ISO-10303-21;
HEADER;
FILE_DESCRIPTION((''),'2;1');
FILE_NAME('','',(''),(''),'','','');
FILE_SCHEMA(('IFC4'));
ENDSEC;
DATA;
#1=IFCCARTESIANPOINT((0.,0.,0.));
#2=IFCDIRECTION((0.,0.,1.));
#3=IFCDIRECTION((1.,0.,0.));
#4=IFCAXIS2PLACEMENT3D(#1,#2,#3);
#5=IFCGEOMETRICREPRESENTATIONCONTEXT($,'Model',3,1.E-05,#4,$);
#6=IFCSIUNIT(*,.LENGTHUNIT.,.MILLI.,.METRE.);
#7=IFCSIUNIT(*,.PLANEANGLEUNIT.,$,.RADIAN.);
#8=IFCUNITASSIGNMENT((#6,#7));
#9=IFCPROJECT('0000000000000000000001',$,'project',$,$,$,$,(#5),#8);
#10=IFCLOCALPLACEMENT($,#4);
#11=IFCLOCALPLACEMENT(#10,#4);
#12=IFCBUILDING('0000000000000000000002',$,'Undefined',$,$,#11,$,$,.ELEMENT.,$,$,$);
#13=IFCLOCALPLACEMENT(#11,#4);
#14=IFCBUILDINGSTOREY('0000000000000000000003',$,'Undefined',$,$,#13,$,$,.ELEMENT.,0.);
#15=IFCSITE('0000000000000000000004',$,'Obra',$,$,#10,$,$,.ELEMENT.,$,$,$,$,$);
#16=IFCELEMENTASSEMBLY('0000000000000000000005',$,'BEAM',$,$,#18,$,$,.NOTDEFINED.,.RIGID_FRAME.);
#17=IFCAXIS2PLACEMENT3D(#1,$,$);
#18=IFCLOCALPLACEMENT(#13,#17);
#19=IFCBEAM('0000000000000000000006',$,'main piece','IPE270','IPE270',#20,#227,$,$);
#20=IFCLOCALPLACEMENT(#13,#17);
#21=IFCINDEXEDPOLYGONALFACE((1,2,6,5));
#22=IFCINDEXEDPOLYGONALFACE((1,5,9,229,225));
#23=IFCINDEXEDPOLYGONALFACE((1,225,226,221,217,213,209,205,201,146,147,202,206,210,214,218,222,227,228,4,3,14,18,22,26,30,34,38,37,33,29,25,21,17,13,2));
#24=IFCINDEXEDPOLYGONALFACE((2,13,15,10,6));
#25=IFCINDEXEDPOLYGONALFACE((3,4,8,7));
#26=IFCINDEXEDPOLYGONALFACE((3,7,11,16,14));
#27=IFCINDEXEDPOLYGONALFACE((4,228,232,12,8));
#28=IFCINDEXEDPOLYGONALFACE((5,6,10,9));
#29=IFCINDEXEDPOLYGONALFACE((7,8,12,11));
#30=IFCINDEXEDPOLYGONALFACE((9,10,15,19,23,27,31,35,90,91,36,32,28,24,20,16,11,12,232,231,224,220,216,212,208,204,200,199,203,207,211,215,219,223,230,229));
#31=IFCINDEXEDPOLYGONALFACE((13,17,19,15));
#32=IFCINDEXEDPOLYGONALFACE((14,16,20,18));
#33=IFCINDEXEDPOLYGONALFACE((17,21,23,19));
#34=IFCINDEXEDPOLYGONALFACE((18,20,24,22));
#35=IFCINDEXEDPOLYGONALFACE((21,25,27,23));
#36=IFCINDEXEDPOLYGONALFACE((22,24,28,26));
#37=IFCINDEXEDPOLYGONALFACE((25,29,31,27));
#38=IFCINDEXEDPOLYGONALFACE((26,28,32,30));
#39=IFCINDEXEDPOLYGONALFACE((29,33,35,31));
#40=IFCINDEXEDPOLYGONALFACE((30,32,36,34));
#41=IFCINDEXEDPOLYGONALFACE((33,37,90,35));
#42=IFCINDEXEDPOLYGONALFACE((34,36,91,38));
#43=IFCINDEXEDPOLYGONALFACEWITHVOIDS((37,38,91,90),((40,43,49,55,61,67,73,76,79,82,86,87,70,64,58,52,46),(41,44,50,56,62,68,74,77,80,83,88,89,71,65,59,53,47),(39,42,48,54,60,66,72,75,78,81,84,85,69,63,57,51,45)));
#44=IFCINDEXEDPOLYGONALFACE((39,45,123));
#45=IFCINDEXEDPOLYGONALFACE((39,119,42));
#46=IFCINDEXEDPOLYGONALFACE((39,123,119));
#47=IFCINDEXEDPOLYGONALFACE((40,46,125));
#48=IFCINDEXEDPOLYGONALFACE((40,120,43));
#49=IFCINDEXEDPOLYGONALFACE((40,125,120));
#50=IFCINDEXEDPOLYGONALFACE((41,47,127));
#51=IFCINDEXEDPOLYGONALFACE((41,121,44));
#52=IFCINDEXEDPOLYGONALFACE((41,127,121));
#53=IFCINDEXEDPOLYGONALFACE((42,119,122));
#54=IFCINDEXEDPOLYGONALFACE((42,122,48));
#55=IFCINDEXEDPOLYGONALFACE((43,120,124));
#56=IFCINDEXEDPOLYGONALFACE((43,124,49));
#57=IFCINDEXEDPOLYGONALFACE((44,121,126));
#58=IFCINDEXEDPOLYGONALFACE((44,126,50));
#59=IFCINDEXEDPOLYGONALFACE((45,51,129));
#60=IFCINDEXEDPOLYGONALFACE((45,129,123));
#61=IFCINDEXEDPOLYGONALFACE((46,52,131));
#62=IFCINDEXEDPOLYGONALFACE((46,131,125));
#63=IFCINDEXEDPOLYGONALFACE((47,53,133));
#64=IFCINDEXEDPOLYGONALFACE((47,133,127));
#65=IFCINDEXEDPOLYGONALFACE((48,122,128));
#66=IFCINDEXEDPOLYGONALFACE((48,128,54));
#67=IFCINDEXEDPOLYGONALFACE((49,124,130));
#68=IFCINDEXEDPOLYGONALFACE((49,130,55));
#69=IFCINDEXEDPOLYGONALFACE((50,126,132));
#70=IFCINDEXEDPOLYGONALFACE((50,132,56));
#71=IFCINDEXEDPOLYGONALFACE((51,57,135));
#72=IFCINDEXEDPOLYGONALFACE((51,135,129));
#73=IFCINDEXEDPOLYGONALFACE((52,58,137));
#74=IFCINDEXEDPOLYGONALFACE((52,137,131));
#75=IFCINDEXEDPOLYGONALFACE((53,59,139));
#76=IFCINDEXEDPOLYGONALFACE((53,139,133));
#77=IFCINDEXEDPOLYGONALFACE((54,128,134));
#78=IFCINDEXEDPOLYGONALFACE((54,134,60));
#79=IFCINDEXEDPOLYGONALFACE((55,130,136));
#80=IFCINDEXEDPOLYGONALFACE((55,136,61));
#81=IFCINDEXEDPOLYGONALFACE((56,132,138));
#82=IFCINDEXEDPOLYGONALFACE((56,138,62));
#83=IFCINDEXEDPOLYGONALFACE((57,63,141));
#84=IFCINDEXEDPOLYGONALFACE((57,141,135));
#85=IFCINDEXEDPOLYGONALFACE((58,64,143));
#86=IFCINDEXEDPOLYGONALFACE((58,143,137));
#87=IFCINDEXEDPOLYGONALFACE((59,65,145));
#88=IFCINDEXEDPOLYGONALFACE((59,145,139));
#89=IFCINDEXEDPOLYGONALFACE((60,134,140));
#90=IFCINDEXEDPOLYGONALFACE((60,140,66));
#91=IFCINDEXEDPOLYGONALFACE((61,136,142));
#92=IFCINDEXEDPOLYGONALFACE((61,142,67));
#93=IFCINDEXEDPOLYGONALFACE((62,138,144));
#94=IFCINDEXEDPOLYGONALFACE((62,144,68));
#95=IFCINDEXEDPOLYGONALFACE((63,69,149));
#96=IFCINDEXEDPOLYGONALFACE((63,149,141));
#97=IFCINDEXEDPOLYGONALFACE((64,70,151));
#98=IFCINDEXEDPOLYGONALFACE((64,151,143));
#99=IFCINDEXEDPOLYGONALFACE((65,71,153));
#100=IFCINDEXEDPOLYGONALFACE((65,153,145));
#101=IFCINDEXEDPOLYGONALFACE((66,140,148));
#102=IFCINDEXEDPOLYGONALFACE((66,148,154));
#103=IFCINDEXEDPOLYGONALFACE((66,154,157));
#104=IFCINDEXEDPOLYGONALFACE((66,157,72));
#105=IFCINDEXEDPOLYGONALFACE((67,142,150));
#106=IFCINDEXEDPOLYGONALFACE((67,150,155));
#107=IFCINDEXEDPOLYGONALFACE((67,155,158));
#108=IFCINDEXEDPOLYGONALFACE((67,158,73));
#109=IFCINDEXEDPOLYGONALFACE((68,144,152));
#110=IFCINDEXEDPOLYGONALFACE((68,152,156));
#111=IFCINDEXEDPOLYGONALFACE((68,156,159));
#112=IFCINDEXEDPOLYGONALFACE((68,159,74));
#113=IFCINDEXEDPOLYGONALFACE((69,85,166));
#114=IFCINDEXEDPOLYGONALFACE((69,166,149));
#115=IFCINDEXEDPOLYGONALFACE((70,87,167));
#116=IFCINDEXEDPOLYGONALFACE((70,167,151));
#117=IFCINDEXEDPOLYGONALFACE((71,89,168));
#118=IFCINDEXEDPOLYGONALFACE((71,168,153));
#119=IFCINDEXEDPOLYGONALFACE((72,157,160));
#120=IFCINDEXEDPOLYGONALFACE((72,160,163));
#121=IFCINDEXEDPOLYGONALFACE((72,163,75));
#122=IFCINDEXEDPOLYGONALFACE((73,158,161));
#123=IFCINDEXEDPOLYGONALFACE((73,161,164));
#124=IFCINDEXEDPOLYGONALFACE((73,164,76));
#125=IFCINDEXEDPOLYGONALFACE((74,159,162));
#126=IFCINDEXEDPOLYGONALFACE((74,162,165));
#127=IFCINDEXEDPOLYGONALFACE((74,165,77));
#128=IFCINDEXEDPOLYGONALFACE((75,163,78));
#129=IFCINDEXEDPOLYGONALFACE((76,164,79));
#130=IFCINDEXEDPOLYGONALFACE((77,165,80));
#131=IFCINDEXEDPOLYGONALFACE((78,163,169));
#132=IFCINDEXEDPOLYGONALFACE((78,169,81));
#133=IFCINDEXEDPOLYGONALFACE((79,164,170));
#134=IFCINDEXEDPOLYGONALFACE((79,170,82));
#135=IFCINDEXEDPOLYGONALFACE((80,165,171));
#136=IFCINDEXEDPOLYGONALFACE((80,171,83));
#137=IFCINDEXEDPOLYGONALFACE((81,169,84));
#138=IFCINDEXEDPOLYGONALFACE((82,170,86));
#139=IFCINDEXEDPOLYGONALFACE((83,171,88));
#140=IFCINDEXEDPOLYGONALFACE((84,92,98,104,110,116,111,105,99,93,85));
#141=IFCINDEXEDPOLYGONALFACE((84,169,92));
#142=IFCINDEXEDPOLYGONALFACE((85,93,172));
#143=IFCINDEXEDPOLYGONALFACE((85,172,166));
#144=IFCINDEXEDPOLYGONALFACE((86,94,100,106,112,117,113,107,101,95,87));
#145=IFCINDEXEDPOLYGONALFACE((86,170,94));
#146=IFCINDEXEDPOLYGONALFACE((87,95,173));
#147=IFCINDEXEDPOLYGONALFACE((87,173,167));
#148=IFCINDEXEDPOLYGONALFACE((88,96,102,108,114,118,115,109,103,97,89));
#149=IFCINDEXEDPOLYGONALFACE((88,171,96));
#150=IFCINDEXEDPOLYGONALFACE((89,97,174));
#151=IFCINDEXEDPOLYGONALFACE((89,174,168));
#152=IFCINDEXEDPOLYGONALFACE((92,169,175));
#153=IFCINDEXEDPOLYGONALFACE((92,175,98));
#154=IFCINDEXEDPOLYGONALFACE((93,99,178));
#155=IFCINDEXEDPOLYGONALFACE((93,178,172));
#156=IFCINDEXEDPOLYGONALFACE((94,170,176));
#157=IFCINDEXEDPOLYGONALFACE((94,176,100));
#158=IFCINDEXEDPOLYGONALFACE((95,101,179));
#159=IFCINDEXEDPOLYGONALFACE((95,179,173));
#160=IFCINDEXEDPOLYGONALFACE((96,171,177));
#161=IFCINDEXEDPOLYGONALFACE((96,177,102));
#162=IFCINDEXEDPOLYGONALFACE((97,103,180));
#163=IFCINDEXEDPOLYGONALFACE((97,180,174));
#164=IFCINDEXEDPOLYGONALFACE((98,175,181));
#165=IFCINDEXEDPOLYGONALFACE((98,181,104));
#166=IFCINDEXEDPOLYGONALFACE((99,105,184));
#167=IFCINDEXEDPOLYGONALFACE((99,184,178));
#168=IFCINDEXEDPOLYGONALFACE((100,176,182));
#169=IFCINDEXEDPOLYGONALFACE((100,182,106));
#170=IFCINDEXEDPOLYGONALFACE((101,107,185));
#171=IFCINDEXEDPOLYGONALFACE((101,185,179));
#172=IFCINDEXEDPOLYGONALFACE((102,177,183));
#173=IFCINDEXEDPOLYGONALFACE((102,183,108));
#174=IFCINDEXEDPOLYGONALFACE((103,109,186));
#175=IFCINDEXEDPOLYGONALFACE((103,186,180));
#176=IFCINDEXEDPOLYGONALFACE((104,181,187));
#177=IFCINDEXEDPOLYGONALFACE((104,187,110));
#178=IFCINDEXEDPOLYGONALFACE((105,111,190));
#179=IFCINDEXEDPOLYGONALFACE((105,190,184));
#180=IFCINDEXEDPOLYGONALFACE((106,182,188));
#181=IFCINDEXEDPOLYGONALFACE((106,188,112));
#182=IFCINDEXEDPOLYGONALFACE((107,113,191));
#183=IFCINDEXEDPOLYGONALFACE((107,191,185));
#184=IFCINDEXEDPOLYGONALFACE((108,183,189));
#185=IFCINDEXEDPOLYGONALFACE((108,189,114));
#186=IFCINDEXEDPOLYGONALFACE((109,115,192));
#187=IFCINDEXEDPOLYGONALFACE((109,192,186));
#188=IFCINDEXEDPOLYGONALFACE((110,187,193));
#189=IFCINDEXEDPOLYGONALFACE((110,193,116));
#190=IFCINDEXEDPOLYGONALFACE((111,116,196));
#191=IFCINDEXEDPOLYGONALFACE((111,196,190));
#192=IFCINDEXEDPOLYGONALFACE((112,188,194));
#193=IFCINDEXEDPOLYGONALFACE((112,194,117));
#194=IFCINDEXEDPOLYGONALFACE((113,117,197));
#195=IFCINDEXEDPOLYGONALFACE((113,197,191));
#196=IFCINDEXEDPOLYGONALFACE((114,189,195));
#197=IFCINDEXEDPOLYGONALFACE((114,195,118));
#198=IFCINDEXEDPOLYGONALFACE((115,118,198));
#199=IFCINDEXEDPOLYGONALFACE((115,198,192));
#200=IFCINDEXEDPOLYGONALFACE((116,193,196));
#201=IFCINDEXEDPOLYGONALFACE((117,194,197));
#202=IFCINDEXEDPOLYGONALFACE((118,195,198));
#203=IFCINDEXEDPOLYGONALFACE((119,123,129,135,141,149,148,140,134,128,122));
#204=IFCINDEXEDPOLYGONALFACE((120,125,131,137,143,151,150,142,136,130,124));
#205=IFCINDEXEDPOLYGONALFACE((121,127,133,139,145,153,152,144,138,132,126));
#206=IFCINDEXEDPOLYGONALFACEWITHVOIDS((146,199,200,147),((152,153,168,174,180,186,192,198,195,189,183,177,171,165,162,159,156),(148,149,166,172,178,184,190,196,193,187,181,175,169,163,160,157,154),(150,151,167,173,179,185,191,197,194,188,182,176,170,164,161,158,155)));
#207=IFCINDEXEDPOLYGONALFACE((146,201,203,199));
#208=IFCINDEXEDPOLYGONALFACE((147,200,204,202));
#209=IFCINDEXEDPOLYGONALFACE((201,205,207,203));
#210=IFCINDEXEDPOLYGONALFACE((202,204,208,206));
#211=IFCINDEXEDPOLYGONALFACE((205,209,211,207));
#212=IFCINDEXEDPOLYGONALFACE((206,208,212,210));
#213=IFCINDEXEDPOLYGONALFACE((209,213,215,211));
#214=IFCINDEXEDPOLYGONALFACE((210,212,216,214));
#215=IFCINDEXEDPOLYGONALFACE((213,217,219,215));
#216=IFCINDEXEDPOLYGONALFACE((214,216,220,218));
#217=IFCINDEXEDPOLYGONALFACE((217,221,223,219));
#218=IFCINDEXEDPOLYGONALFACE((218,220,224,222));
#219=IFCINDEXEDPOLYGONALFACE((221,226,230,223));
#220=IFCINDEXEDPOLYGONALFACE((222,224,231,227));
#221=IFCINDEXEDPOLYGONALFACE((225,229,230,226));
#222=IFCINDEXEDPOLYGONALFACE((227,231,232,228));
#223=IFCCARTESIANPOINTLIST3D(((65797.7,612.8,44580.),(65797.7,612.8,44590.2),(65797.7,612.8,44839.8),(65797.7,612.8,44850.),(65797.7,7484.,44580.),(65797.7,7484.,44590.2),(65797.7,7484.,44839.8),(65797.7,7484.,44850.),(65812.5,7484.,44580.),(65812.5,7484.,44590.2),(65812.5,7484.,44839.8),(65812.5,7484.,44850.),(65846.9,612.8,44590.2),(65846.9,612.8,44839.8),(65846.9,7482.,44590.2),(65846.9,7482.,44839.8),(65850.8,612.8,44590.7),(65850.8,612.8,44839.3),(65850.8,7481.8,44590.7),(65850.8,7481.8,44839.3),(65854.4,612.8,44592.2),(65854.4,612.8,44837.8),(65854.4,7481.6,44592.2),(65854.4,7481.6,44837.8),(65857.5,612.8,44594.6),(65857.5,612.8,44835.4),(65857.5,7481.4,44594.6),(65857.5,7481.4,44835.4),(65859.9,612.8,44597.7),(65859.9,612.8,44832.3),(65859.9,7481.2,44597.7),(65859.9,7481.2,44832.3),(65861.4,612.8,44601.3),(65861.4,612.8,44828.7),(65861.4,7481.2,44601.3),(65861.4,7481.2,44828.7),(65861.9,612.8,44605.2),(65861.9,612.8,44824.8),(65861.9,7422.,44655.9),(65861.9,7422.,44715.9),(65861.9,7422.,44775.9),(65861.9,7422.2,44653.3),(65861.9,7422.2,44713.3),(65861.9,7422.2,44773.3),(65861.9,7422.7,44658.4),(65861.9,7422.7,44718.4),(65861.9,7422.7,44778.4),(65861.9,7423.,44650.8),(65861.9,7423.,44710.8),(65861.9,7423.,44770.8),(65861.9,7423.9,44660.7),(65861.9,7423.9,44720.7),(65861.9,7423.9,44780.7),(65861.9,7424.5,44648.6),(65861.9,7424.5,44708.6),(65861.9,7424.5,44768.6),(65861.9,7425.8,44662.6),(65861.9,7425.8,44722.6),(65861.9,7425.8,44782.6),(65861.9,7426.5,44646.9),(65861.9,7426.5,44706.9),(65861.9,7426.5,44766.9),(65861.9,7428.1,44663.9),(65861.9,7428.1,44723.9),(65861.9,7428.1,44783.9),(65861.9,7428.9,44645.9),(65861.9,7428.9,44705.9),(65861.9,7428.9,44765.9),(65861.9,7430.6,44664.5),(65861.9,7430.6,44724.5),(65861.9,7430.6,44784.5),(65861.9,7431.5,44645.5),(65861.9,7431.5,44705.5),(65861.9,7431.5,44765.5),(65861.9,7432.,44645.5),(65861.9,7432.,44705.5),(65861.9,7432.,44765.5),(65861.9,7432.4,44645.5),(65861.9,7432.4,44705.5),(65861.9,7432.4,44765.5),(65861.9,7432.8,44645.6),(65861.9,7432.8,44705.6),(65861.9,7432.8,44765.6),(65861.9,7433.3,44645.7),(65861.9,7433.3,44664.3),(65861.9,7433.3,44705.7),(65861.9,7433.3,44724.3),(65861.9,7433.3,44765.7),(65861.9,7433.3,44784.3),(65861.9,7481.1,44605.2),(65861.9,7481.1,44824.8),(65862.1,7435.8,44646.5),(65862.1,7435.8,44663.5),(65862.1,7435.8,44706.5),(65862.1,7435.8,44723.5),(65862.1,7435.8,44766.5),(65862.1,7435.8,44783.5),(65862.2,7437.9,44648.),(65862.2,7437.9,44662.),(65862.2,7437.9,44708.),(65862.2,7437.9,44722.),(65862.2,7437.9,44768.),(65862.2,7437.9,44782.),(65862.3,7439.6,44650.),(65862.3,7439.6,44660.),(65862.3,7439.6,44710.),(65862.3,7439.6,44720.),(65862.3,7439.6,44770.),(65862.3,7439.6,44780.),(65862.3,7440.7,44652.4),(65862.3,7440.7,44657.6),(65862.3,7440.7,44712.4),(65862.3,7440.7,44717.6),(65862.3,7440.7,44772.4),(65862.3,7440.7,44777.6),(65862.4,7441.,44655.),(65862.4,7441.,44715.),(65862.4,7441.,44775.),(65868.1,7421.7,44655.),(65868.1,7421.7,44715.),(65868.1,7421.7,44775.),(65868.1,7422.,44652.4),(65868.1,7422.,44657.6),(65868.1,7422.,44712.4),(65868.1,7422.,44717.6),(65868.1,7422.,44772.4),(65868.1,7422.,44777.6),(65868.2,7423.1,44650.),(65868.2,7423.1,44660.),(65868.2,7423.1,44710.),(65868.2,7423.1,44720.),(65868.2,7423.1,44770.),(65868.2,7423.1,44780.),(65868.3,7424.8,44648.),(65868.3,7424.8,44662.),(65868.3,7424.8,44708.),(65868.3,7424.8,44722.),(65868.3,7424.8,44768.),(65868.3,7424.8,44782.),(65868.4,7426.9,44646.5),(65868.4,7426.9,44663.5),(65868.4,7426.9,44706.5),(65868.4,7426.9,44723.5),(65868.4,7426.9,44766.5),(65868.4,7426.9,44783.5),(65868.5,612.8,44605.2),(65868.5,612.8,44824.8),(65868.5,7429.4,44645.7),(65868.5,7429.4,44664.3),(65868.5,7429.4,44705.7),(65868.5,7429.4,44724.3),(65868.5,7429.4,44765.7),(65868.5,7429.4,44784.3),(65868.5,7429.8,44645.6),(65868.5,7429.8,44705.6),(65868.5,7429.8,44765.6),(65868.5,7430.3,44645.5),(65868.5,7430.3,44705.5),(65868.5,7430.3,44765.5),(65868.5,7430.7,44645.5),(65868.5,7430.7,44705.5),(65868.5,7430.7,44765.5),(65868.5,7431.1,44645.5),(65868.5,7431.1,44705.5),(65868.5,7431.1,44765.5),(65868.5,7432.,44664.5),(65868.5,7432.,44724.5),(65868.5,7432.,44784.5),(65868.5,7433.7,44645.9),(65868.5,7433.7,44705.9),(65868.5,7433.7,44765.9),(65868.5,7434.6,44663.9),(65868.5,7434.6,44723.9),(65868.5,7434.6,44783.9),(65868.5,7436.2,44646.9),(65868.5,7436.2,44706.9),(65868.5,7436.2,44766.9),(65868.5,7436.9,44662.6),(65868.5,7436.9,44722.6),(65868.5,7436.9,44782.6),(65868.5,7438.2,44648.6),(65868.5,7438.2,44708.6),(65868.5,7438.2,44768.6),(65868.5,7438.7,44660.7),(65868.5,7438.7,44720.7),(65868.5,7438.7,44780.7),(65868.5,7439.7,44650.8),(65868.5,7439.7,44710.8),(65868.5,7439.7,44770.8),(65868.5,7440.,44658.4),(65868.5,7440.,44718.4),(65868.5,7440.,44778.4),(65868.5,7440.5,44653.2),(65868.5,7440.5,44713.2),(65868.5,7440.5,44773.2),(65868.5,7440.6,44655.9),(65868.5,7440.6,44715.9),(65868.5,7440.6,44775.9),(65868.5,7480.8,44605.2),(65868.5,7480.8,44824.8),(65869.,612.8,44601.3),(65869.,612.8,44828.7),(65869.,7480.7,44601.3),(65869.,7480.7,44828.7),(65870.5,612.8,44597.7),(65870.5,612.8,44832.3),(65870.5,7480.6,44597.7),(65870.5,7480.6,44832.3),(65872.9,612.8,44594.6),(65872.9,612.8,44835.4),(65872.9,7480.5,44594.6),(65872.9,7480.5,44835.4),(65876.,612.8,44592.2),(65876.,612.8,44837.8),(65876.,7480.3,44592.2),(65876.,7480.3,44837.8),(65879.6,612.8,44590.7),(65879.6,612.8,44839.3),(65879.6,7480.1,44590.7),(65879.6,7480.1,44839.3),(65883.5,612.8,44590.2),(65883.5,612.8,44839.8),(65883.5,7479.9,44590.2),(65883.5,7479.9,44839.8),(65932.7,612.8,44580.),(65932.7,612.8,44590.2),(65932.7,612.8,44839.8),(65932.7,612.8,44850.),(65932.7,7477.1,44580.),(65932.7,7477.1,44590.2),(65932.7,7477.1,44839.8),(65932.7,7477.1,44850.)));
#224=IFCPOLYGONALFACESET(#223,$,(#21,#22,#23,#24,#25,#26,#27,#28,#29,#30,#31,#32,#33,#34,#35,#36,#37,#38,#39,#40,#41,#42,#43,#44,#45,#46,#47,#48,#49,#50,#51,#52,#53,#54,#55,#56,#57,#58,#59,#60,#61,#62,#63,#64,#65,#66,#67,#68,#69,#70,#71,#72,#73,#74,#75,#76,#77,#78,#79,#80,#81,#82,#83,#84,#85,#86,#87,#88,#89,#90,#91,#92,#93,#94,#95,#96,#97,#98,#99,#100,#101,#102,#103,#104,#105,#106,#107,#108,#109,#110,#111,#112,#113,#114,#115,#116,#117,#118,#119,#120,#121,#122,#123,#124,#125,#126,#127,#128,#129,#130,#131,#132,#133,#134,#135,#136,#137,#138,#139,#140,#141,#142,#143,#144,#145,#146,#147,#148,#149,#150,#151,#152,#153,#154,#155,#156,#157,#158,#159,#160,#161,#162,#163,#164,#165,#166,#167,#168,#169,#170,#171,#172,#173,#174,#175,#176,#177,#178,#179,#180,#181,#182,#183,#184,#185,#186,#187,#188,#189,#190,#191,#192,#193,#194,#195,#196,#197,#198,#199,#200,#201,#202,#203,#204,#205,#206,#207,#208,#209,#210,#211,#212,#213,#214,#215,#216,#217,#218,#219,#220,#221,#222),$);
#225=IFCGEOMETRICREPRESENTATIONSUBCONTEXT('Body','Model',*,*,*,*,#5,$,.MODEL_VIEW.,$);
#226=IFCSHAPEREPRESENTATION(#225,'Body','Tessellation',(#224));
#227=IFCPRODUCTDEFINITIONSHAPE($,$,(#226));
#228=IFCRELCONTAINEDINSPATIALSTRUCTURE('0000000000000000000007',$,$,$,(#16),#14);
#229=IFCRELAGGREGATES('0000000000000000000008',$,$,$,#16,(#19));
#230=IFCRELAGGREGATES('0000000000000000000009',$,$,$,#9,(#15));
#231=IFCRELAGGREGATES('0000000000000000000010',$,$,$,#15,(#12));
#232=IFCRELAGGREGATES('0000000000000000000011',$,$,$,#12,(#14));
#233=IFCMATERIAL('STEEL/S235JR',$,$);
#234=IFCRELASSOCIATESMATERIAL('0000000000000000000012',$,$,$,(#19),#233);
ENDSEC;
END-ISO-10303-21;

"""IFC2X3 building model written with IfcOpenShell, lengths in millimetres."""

from ifc_helpers import new_model, si_unit, frame, origin_with_axes, origin_2d_with_axis, place, context, subcontext, project, spatial, circle, i_section, extrude, clip, halfspace, source, transform, mapped, material, element, aggregate, save


model = new_model("IFC2X3")

# Units and contexts
model_context = context("Model", 3, precision=1e-05, world=origin_with_axes())
body_context = subcontext(model_context, "Body", "Model", "MODEL_VIEW")
ifc_project = project(units=[si_unit("LENGTHUNIT", "METRE", prefix="MILLI"), si_unit("PLANEANGLEUNIT", "RADIAN")], contexts=[model_context])

# Site, building, storey
site_placement = place(None, origin_with_axes())
site = spatial("IfcSite", under=ifc_project, at=site_placement, Name="Obra", CompositionType="ELEMENT")
building_placement = place(site_placement, origin_with_axes())
building = spatial("IfcBuilding", under=site, at=building_placement, Name="Undefined", CompositionType="ELEMENT")
storey_placement = place(building_placement, origin_with_axes())
storey = spatial("IfcBuildingStorey", under=building, at=storey_placement, Name="Undefined", CompositionType="ELEMENT", Elevation=0.0)

# Shared definitions
ifc_material_1 = material(Name="STEEL/S235JR")

# Element assembly, beam, opening
assembly_1_placement = place(storey_placement, origin_with_axes())
assembly_1 = element("IfcElementAssembly", 1, at=assembly_1_placement, inside=storey, Name="BEAM", AssemblyPlace="NOTDEFINED", PredefinedType="RIGID_FRAME")
beam_1_placement = place(assembly_1_placement, frame((65865.2, 7484.0, 44715.0), z_axis=(0.0, 0.0, 1.0), x_axis=(0.0, -1.0, 0.0)))
beam_1 = element("IfcBeam", 2, at=beam_1_placement, material=ifc_material_1, Name="main piece", Description="IPE270", ObjectType="IPE270", context=body_context, shape_type="Clipping", body=[
    clip(extrude(i_section(OverallWidth=135.0, OverallDepth=270.0, WebThickness=6.6, FlangeThickness=10.2, FilletRadius=15.0, at=origin_2d_with_axis()), frame((6871.2, 0.0, 0.0), z_axis=(-1.0, 0.0, 0.0), x_axis=(0.0, -1.0, 0.0)), (0.0, 0.0, 1.0), 6871.2), halfspace(frame((4.8, 30.8, -120.0), z_axis=(-0.998369, 0.057091, 0.0), x_axis=(0.0, 0.0, 1.0)), False)),
])
shared_shape_1 = source(origin_with_axes(), body_context, "Body", "SweptSolid", [
    extrude(circle(Radius=9.5, at=origin_2d_with_axis()), frame((0.0, 28.6, 0.0), z_axis=(0.0, 1.0, 0.0), x_axis=(1.0, 0.0, 0.0)), (0.0, 0.0, 1.0), 6.8),
])
opening_1_placement = place(assembly_1_placement, frame((65836.1, 7483.1, 44835.0), z_axis=(-0.05711, -0.998368, 0.0), x_axis=(0.0, 0.0, -1.0)))
element("IfcOpeningElement", 3, at=opening_1_placement, cuts=beam_1, ObjectType="Opening", context=body_context, shape_type="MappedRepresentation", body=[
    mapped(shared_shape_1, transform((60.0, 0.0, 50.0))),
    mapped(shared_shape_1, transform((120.0, 0.0, 50.0))),
    mapped(shared_shape_1, transform((180.0, 0.0, 50.0))),
])
aggregate(assembly_1, [beam_1])

save(model, "model.ifc")
